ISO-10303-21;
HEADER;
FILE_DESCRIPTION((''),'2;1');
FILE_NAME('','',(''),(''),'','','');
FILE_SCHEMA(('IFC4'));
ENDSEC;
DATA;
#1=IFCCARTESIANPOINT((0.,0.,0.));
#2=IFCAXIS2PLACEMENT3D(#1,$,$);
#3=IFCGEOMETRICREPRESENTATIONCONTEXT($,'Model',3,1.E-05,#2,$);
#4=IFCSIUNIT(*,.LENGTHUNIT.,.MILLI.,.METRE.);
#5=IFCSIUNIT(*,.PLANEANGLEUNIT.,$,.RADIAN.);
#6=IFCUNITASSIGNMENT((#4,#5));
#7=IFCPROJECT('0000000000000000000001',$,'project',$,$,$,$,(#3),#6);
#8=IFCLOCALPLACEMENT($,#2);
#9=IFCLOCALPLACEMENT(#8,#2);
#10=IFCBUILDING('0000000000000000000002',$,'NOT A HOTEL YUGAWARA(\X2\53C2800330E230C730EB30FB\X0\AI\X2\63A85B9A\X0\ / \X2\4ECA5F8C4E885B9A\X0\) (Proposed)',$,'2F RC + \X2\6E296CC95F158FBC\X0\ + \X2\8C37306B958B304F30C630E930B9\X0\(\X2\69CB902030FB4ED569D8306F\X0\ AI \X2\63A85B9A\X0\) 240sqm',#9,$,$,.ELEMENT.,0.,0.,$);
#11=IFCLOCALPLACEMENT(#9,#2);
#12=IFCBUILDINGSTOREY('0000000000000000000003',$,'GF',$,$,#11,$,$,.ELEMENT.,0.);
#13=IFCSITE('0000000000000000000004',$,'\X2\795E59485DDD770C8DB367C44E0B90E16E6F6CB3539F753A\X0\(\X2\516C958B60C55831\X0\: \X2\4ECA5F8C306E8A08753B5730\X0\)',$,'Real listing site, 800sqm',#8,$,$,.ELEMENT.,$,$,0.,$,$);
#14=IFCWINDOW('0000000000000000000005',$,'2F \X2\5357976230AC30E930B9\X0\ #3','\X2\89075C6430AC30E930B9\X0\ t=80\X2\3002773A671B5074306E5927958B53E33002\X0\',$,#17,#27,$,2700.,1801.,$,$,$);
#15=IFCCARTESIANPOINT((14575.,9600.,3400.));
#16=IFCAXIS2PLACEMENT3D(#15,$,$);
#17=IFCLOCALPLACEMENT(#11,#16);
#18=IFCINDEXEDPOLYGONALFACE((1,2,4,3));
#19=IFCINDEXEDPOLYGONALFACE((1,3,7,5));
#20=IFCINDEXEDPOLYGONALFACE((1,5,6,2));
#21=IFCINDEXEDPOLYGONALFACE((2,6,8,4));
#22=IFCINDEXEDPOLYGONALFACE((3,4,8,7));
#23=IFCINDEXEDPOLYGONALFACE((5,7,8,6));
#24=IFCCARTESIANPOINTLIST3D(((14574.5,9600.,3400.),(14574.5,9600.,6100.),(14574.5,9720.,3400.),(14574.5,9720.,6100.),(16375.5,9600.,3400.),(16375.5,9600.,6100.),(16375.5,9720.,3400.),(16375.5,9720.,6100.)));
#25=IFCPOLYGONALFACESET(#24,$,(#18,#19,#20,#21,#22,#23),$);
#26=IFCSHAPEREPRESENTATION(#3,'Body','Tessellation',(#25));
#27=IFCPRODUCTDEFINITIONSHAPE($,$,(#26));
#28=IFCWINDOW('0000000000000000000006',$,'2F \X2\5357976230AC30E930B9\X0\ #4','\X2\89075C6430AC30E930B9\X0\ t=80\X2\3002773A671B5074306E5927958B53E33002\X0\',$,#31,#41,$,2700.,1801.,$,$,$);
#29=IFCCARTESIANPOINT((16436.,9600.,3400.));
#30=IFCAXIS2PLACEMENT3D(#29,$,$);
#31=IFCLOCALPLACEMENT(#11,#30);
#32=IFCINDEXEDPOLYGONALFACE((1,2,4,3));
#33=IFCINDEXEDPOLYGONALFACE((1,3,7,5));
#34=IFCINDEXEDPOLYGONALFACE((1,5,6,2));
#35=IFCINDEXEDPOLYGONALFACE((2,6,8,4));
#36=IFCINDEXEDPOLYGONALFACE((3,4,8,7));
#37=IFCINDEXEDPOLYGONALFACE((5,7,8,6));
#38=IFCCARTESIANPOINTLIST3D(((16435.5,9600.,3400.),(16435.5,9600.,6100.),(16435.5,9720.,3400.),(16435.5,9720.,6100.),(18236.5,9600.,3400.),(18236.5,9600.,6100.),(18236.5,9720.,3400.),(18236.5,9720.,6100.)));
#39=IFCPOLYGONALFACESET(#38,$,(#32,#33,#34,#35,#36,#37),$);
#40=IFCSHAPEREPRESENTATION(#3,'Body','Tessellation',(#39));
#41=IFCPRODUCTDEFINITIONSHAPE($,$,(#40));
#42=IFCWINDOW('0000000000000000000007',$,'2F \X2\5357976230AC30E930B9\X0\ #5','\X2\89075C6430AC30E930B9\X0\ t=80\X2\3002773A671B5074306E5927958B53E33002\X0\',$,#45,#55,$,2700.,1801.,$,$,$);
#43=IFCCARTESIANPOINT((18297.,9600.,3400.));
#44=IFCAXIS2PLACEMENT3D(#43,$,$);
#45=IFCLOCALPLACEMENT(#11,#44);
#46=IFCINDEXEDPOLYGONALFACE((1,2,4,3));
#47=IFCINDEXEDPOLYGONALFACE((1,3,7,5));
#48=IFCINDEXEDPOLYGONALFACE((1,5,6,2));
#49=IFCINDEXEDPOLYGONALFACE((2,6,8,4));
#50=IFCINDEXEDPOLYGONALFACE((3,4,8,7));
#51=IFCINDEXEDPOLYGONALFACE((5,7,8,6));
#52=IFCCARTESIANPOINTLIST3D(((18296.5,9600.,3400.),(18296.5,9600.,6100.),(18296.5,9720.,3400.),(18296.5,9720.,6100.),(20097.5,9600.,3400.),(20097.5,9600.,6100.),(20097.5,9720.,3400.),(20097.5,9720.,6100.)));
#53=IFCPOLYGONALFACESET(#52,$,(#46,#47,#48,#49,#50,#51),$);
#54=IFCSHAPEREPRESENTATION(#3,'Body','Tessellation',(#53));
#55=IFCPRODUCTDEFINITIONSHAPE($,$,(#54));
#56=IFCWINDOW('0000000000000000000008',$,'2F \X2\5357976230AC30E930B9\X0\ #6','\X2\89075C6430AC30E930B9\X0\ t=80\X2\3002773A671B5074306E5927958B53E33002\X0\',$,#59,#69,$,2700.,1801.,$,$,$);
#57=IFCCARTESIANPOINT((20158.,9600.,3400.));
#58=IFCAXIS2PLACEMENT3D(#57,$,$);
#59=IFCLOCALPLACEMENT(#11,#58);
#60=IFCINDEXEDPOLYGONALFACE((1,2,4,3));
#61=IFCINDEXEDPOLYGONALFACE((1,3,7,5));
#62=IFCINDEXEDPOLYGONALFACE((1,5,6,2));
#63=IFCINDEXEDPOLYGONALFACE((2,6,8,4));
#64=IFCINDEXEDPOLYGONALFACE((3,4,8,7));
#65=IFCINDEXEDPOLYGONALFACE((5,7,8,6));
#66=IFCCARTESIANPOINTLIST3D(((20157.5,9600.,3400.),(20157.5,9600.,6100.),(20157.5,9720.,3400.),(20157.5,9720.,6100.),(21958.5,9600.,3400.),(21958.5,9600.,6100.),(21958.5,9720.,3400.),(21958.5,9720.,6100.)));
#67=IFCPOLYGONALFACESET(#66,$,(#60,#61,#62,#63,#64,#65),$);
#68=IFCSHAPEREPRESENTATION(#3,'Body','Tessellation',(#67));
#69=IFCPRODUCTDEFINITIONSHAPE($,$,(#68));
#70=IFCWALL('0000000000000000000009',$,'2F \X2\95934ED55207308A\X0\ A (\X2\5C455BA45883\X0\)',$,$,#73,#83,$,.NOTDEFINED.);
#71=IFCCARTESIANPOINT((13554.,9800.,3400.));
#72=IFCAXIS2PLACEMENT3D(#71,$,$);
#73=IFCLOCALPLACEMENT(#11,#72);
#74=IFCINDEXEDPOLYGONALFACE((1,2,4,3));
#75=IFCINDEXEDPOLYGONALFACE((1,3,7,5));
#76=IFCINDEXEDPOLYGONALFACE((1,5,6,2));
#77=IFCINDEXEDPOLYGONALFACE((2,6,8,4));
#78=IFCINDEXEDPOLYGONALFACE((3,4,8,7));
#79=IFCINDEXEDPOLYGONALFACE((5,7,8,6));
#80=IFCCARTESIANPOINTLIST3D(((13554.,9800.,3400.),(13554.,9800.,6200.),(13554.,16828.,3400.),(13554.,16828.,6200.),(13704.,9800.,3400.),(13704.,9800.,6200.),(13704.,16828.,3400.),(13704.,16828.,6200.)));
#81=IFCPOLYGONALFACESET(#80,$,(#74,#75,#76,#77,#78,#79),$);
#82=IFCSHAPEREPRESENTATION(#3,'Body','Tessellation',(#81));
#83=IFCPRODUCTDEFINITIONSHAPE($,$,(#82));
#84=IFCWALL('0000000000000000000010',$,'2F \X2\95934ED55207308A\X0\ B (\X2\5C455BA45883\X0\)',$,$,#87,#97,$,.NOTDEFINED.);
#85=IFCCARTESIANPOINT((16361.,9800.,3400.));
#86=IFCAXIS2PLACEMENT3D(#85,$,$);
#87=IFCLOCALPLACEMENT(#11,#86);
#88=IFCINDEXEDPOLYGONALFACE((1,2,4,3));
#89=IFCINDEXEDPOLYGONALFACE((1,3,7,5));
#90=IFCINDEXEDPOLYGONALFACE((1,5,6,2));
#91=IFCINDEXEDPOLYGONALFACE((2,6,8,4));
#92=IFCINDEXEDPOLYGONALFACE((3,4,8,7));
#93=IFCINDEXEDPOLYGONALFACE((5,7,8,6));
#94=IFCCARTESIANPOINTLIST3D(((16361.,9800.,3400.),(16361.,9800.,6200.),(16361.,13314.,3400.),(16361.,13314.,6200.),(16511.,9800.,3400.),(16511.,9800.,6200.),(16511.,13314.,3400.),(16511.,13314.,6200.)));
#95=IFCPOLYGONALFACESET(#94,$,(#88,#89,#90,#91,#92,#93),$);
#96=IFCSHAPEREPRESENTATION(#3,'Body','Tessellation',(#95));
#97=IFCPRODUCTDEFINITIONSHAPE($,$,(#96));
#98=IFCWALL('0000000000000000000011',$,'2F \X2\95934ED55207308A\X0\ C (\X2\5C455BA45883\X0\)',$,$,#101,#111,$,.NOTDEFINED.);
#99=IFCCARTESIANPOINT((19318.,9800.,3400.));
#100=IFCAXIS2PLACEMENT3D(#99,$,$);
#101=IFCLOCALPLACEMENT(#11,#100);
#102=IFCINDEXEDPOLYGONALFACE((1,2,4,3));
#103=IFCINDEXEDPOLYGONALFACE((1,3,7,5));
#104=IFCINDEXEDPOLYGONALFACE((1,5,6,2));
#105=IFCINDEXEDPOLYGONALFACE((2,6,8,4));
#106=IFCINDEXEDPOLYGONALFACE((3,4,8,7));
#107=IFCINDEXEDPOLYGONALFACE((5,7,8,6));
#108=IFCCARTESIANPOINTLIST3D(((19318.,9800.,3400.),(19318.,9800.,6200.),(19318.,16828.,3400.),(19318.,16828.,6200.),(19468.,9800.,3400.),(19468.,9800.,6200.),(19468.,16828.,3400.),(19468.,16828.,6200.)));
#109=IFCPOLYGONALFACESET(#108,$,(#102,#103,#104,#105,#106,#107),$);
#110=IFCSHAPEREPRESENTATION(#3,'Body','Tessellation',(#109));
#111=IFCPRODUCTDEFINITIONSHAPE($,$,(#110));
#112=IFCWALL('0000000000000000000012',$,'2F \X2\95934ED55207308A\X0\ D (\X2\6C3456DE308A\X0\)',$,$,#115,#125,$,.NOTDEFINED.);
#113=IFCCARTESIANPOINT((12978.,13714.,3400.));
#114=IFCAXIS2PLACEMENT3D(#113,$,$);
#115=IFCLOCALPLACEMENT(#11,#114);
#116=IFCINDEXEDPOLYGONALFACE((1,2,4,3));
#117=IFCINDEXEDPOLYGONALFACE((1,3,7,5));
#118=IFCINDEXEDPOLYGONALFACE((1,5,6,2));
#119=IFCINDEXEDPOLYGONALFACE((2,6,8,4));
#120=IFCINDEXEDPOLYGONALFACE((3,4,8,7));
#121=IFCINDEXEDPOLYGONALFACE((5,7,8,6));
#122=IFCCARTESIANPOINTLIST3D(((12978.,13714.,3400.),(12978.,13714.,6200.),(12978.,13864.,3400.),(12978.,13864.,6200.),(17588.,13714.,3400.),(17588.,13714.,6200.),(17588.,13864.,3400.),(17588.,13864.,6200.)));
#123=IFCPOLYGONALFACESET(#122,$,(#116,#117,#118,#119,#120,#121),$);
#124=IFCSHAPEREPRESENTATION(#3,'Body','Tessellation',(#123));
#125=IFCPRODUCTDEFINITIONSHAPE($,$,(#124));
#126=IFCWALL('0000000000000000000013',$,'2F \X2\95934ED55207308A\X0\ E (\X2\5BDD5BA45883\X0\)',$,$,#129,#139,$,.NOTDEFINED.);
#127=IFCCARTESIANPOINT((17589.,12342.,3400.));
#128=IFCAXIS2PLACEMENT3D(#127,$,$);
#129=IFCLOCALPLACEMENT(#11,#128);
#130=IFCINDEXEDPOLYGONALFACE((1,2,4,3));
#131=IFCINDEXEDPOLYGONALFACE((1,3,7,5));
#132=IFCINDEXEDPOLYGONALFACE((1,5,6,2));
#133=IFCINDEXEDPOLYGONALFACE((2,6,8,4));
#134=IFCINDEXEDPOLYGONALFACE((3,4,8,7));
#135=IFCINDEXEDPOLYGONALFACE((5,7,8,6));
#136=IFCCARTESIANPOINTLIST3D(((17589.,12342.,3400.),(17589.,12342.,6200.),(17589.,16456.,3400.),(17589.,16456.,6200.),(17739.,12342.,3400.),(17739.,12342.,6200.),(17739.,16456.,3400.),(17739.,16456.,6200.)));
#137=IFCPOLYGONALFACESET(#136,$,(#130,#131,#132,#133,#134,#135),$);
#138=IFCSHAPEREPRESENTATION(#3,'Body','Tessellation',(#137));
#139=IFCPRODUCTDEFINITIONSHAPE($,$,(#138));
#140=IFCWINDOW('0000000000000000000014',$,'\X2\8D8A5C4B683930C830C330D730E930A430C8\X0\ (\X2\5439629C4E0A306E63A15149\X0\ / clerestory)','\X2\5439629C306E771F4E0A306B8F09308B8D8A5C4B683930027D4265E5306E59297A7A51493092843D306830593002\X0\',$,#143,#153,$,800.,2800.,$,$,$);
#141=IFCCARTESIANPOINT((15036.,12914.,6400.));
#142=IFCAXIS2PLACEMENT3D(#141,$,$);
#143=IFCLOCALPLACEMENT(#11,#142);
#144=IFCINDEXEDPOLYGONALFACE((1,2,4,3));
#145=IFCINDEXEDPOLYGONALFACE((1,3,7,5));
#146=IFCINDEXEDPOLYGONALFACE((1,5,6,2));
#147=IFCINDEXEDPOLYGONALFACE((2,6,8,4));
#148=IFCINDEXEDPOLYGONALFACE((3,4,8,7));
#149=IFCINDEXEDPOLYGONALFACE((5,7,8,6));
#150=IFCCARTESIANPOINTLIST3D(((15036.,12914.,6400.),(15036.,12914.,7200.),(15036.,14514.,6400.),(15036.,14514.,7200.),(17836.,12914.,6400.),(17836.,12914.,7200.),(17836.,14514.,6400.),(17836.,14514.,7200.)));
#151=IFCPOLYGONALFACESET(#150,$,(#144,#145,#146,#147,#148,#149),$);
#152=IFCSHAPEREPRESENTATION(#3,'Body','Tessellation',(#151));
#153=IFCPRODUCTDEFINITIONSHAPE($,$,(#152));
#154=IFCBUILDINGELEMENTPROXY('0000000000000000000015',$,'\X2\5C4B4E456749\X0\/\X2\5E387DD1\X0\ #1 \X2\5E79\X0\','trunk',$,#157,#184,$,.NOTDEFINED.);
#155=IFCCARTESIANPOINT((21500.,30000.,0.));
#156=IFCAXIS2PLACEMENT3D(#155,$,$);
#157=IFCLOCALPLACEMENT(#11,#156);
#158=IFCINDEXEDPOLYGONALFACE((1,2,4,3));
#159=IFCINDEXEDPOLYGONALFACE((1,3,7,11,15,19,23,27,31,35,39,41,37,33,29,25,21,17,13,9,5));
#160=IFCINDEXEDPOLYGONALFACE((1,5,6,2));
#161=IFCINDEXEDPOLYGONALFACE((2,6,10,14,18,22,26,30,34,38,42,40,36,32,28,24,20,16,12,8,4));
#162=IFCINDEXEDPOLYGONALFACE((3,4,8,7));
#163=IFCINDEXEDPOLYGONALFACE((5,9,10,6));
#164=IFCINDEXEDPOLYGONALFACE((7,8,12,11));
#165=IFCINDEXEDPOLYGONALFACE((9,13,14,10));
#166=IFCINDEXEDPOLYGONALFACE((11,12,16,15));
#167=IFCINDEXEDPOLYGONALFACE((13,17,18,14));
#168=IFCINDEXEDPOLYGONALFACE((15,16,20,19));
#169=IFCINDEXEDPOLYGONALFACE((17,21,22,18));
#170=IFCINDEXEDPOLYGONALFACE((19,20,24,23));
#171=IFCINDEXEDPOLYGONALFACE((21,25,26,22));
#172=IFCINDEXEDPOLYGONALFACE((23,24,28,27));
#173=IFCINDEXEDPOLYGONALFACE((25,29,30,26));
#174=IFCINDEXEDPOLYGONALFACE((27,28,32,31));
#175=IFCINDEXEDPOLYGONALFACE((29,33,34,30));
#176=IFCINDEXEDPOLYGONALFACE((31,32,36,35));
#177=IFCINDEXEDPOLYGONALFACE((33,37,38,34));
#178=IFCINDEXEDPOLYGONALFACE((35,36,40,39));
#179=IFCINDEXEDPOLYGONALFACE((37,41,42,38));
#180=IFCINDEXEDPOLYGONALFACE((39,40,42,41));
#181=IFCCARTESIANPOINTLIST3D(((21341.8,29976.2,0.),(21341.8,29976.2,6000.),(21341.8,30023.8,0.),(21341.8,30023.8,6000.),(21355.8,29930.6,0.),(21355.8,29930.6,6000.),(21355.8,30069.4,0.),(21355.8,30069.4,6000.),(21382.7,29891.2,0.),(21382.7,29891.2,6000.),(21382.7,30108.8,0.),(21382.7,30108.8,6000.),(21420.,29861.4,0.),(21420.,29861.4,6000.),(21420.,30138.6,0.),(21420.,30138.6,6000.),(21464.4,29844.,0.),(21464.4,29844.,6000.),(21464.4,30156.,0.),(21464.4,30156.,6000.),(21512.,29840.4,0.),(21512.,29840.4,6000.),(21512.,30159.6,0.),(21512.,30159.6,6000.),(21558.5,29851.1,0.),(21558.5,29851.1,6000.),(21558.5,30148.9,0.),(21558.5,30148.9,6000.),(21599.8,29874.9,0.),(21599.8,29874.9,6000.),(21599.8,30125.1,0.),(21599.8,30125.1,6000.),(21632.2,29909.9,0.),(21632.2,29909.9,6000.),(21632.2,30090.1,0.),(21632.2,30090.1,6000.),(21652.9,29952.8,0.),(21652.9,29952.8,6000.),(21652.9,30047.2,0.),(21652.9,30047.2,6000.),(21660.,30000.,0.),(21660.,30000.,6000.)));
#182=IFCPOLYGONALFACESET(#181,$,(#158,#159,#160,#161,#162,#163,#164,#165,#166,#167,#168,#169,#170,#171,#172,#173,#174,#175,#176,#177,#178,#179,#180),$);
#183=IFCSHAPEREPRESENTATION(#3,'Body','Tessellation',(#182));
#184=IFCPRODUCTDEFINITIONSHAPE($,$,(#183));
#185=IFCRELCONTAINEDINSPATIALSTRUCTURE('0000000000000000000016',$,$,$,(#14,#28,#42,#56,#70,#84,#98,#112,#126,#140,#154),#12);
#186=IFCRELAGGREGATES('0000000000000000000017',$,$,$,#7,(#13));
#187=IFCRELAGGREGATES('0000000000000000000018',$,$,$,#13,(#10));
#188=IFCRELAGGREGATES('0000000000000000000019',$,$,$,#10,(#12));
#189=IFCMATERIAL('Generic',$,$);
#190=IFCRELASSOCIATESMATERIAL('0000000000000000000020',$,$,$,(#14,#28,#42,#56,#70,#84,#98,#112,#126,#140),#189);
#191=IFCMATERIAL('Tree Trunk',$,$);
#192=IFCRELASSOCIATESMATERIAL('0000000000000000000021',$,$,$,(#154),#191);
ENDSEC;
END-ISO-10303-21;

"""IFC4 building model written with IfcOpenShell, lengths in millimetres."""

from ifc_helpers import new_model, si_unit, frame, frame_2d, origin, origin_2d, place, context, project, spatial, rectangle, circle, extrude, material, element, save


model = new_model("IFC4")

# Units and contexts
model_context = context("Model", 3, precision=1e-05, world=origin())
ifc_project = project(units=[si_unit("LENGTHUNIT", "METRE", prefix="MILLI"), si_unit("PLANEANGLEUNIT", "RADIAN")], contexts=[model_context])

# Site, building, storey
site_placement = place(None, origin())
site = spatial("IfcSite", under=ifc_project, at=site_placement, Name="神奈川県足柄下郡湯河原町(公開情報: 今後の計画地)", ObjectType="Real listing site, 800sqm", CompositionType="ELEMENT", RefElevation=0.0)
building_placement = place(site_placement, origin())
building = spatial("IfcBuilding", under=site, at=building_placement, Name="NOT A HOTEL YUGAWARA(参考モデル・AI推定 / 今後予定) (Proposed)", ObjectType="2F RC + 温泉引込 + 谷に開くテラス(構造・仕様は AI 推定) 240sqm", CompositionType="ELEMENT", ElevationOfRefHeight=0.0, ElevationOfTerrain=0.0)
storey_placement = place(building_placement, origin())
storey = spatial("IfcBuildingStorey", under=building, at=storey_placement, Name="GF", CompositionType="ELEMENT", Elevation=0.0)

# Shared definitions
ifc_material_1 = material(Name="Generic")

# Windows
window_1_placement = place(storey_placement, frame((14575.0, 9600.0, 3400.0)))
element("IfcWindow", 1, at=window_1_placement, inside=storey, material=ifc_material_1, Name="2F 南面ガラス #3", Description="複層ガラス t=80。眺望側の大開口。", OverallHeight=2700.0, OverallWidth=1801.0, context=model_context, shape_type="SweptSolid", body=[
    extrude(rectangle(XDim=1801.0, YDim=120.0, at=frame_2d((900.0, 60.0))), frame((14575.0, 9600.0, 3400.0)), (0.0, 0.0, 1.0), 2700.0),
])
window_2_placement = place(storey_placement, frame((16436.0, 9600.0, 3400.0)))
element("IfcWindow", 2, at=window_2_placement, inside=storey, material=ifc_material_1, Name="2F 南面ガラス #4", Description="複層ガラス t=80。眺望側の大開口。", OverallHeight=2700.0, OverallWidth=1801.0, context=model_context, shape_type="SweptSolid", body=[
    extrude(rectangle(XDim=1801.0, YDim=120.0, at=frame_2d((900.0, 60.0))), frame((16436.0, 9600.0, 3400.0)), (0.0, 0.0, 1.0), 2700.0),
])
window_3_placement = place(storey_placement, frame((18297.0, 9600.0, 3400.0)))
element("IfcWindow", 3, at=window_3_placement, inside=storey, material=ifc_material_1, Name="2F 南面ガラス #5", Description="複層ガラス t=80。眺望側の大開口。", OverallHeight=2700.0, OverallWidth=1801.0, context=model_context, shape_type="SweptSolid", body=[
    extrude(rectangle(XDim=1801.0, YDim=120.0, at=frame_2d((900.0, 60.0))), frame((18297.0, 9600.0, 3400.0)), (0.0, 0.0, 1.0), 2700.0),
])
window_4_placement = place(storey_placement, frame((20158.0, 9600.0, 3400.0)))
element("IfcWindow", 4, at=window_4_placement, inside=storey, material=ifc_material_1, Name="2F 南面ガラス #6", Description="複層ガラス t=80。眺望側の大開口。", OverallHeight=2700.0, OverallWidth=1801.0, context=model_context, shape_type="SweptSolid", body=[
    extrude(rectangle(XDim=1801.0, YDim=120.0, at=frame_2d((900.0, 60.0))), frame((20158.0, 9600.0, 3400.0)), (0.0, 0.0, 1.0), 2700.0),
])

# Walls
wall_1_placement = place(storey_placement, frame((13554.0, 9800.0, 3400.0)))
element("IfcWall", 5, at=wall_1_placement, inside=storey, material=ifc_material_1, Name="2F 間仕切り A (居室境)", PredefinedType="NOTDEFINED", context=model_context, shape_type="SweptSolid", body=[
    extrude(rectangle(XDim=150.0, YDim=7028.0, at=frame_2d((75.0, 3514.0))), frame((13554.0, 9800.0, 3400.0)), (0.0, 0.0, 1.0), 2800.0),
])
wall_2_placement = place(storey_placement, frame((16361.0, 9800.0, 3400.0)))
element("IfcWall", 6, at=wall_2_placement, inside=storey, material=ifc_material_1, Name="2F 間仕切り B (居室境)", PredefinedType="NOTDEFINED", context=model_context, shape_type="SweptSolid", body=[
    extrude(rectangle(XDim=150.0, YDim=3514.0, at=frame_2d((75.0, 1757.0))), frame((16361.0, 9800.0, 3400.0)), (0.0, 0.0, 1.0), 2800.0),
])
wall_3_placement = place(storey_placement, frame((19318.0, 9800.0, 3400.0)))
element("IfcWall", 7, at=wall_3_placement, inside=storey, material=ifc_material_1, Name="2F 間仕切り C (居室境)", PredefinedType="NOTDEFINED", context=model_context, shape_type="SweptSolid", body=[
    extrude(rectangle(XDim=150.0, YDim=7028.0, at=frame_2d((75.0, 3514.0))), frame((19318.0, 9800.0, 3400.0)), (0.0, 0.0, 1.0), 2800.0),
])
wall_4_placement = place(storey_placement, frame((12978.0, 13714.0, 3400.0)))
element("IfcWall", 8, at=wall_4_placement, inside=storey, material=ifc_material_1, Name="2F 間仕切り D (水回り)", PredefinedType="NOTDEFINED", context=model_context, shape_type="SweptSolid", body=[
    extrude(rectangle(XDim=4610.0, YDim=150.0, at=frame_2d((2305.0, 75.0))), frame((12978.0, 13714.0, 3400.0)), (0.0, 0.0, 1.0), 2800.0),
])
wall_5_placement = place(storey_placement, frame((17589.0, 12342.0, 3400.0)))
element("IfcWall", 9, at=wall_5_placement, inside=storey, material=ifc_material_1, Name="2F 間仕切り E (寝室境)", PredefinedType="NOTDEFINED", context=model_context, shape_type="SweptSolid", body=[
    extrude(rectangle(XDim=150.0, YDim=4114.0, at=frame_2d((75.0, 2057.0))), frame((17589.0, 12342.0, 3400.0)), (0.0, 0.0, 1.0), 2800.0),
])

# Window
window_5_placement = place(storey_placement, frame((15036.0, 12914.0, 6400.0)))
element("IfcWindow", 10, at=window_5_placement, inside=storey, material=ifc_material_1, Name="越屋根トップライト (吹抜上の採光 / clerestory)", Description="吹抜の真上に載る越屋根。終日の天空光を落とす。", OverallHeight=800.0, OverallWidth=2800.0, context=model_context, shape_type="SweptSolid", body=[
    extrude(rectangle(XDim=2800.0, YDim=1600.0, at=frame_2d((1400.0, 800.0))), frame((15036.0, 12914.0, 6400.0)), (0.0, 0.0, 1.0), 800.0),
])

# Building element proxy
ifc_material_2 = material(Name="Tree Trunk")
proxy_1_placement = place(storey_placement, frame((21500.0, 30000.0, 0.0)))
element("IfcBuildingElementProxy", 11, at=proxy_1_placement, inside=storey, material=ifc_material_2, Name="屋久杉/常緑 #1 幹", Description="trunk", PredefinedType="NOTDEFINED", context=model_context, shape_type="SweptSolid", body=[
    extrude(circle(Radius=160.0, at=origin_2d()), frame((21500.0, 30000.0, 0.0)), (0.0, 0.0, 1.0), 6000.0),
])

save(model, "model.ifc")
